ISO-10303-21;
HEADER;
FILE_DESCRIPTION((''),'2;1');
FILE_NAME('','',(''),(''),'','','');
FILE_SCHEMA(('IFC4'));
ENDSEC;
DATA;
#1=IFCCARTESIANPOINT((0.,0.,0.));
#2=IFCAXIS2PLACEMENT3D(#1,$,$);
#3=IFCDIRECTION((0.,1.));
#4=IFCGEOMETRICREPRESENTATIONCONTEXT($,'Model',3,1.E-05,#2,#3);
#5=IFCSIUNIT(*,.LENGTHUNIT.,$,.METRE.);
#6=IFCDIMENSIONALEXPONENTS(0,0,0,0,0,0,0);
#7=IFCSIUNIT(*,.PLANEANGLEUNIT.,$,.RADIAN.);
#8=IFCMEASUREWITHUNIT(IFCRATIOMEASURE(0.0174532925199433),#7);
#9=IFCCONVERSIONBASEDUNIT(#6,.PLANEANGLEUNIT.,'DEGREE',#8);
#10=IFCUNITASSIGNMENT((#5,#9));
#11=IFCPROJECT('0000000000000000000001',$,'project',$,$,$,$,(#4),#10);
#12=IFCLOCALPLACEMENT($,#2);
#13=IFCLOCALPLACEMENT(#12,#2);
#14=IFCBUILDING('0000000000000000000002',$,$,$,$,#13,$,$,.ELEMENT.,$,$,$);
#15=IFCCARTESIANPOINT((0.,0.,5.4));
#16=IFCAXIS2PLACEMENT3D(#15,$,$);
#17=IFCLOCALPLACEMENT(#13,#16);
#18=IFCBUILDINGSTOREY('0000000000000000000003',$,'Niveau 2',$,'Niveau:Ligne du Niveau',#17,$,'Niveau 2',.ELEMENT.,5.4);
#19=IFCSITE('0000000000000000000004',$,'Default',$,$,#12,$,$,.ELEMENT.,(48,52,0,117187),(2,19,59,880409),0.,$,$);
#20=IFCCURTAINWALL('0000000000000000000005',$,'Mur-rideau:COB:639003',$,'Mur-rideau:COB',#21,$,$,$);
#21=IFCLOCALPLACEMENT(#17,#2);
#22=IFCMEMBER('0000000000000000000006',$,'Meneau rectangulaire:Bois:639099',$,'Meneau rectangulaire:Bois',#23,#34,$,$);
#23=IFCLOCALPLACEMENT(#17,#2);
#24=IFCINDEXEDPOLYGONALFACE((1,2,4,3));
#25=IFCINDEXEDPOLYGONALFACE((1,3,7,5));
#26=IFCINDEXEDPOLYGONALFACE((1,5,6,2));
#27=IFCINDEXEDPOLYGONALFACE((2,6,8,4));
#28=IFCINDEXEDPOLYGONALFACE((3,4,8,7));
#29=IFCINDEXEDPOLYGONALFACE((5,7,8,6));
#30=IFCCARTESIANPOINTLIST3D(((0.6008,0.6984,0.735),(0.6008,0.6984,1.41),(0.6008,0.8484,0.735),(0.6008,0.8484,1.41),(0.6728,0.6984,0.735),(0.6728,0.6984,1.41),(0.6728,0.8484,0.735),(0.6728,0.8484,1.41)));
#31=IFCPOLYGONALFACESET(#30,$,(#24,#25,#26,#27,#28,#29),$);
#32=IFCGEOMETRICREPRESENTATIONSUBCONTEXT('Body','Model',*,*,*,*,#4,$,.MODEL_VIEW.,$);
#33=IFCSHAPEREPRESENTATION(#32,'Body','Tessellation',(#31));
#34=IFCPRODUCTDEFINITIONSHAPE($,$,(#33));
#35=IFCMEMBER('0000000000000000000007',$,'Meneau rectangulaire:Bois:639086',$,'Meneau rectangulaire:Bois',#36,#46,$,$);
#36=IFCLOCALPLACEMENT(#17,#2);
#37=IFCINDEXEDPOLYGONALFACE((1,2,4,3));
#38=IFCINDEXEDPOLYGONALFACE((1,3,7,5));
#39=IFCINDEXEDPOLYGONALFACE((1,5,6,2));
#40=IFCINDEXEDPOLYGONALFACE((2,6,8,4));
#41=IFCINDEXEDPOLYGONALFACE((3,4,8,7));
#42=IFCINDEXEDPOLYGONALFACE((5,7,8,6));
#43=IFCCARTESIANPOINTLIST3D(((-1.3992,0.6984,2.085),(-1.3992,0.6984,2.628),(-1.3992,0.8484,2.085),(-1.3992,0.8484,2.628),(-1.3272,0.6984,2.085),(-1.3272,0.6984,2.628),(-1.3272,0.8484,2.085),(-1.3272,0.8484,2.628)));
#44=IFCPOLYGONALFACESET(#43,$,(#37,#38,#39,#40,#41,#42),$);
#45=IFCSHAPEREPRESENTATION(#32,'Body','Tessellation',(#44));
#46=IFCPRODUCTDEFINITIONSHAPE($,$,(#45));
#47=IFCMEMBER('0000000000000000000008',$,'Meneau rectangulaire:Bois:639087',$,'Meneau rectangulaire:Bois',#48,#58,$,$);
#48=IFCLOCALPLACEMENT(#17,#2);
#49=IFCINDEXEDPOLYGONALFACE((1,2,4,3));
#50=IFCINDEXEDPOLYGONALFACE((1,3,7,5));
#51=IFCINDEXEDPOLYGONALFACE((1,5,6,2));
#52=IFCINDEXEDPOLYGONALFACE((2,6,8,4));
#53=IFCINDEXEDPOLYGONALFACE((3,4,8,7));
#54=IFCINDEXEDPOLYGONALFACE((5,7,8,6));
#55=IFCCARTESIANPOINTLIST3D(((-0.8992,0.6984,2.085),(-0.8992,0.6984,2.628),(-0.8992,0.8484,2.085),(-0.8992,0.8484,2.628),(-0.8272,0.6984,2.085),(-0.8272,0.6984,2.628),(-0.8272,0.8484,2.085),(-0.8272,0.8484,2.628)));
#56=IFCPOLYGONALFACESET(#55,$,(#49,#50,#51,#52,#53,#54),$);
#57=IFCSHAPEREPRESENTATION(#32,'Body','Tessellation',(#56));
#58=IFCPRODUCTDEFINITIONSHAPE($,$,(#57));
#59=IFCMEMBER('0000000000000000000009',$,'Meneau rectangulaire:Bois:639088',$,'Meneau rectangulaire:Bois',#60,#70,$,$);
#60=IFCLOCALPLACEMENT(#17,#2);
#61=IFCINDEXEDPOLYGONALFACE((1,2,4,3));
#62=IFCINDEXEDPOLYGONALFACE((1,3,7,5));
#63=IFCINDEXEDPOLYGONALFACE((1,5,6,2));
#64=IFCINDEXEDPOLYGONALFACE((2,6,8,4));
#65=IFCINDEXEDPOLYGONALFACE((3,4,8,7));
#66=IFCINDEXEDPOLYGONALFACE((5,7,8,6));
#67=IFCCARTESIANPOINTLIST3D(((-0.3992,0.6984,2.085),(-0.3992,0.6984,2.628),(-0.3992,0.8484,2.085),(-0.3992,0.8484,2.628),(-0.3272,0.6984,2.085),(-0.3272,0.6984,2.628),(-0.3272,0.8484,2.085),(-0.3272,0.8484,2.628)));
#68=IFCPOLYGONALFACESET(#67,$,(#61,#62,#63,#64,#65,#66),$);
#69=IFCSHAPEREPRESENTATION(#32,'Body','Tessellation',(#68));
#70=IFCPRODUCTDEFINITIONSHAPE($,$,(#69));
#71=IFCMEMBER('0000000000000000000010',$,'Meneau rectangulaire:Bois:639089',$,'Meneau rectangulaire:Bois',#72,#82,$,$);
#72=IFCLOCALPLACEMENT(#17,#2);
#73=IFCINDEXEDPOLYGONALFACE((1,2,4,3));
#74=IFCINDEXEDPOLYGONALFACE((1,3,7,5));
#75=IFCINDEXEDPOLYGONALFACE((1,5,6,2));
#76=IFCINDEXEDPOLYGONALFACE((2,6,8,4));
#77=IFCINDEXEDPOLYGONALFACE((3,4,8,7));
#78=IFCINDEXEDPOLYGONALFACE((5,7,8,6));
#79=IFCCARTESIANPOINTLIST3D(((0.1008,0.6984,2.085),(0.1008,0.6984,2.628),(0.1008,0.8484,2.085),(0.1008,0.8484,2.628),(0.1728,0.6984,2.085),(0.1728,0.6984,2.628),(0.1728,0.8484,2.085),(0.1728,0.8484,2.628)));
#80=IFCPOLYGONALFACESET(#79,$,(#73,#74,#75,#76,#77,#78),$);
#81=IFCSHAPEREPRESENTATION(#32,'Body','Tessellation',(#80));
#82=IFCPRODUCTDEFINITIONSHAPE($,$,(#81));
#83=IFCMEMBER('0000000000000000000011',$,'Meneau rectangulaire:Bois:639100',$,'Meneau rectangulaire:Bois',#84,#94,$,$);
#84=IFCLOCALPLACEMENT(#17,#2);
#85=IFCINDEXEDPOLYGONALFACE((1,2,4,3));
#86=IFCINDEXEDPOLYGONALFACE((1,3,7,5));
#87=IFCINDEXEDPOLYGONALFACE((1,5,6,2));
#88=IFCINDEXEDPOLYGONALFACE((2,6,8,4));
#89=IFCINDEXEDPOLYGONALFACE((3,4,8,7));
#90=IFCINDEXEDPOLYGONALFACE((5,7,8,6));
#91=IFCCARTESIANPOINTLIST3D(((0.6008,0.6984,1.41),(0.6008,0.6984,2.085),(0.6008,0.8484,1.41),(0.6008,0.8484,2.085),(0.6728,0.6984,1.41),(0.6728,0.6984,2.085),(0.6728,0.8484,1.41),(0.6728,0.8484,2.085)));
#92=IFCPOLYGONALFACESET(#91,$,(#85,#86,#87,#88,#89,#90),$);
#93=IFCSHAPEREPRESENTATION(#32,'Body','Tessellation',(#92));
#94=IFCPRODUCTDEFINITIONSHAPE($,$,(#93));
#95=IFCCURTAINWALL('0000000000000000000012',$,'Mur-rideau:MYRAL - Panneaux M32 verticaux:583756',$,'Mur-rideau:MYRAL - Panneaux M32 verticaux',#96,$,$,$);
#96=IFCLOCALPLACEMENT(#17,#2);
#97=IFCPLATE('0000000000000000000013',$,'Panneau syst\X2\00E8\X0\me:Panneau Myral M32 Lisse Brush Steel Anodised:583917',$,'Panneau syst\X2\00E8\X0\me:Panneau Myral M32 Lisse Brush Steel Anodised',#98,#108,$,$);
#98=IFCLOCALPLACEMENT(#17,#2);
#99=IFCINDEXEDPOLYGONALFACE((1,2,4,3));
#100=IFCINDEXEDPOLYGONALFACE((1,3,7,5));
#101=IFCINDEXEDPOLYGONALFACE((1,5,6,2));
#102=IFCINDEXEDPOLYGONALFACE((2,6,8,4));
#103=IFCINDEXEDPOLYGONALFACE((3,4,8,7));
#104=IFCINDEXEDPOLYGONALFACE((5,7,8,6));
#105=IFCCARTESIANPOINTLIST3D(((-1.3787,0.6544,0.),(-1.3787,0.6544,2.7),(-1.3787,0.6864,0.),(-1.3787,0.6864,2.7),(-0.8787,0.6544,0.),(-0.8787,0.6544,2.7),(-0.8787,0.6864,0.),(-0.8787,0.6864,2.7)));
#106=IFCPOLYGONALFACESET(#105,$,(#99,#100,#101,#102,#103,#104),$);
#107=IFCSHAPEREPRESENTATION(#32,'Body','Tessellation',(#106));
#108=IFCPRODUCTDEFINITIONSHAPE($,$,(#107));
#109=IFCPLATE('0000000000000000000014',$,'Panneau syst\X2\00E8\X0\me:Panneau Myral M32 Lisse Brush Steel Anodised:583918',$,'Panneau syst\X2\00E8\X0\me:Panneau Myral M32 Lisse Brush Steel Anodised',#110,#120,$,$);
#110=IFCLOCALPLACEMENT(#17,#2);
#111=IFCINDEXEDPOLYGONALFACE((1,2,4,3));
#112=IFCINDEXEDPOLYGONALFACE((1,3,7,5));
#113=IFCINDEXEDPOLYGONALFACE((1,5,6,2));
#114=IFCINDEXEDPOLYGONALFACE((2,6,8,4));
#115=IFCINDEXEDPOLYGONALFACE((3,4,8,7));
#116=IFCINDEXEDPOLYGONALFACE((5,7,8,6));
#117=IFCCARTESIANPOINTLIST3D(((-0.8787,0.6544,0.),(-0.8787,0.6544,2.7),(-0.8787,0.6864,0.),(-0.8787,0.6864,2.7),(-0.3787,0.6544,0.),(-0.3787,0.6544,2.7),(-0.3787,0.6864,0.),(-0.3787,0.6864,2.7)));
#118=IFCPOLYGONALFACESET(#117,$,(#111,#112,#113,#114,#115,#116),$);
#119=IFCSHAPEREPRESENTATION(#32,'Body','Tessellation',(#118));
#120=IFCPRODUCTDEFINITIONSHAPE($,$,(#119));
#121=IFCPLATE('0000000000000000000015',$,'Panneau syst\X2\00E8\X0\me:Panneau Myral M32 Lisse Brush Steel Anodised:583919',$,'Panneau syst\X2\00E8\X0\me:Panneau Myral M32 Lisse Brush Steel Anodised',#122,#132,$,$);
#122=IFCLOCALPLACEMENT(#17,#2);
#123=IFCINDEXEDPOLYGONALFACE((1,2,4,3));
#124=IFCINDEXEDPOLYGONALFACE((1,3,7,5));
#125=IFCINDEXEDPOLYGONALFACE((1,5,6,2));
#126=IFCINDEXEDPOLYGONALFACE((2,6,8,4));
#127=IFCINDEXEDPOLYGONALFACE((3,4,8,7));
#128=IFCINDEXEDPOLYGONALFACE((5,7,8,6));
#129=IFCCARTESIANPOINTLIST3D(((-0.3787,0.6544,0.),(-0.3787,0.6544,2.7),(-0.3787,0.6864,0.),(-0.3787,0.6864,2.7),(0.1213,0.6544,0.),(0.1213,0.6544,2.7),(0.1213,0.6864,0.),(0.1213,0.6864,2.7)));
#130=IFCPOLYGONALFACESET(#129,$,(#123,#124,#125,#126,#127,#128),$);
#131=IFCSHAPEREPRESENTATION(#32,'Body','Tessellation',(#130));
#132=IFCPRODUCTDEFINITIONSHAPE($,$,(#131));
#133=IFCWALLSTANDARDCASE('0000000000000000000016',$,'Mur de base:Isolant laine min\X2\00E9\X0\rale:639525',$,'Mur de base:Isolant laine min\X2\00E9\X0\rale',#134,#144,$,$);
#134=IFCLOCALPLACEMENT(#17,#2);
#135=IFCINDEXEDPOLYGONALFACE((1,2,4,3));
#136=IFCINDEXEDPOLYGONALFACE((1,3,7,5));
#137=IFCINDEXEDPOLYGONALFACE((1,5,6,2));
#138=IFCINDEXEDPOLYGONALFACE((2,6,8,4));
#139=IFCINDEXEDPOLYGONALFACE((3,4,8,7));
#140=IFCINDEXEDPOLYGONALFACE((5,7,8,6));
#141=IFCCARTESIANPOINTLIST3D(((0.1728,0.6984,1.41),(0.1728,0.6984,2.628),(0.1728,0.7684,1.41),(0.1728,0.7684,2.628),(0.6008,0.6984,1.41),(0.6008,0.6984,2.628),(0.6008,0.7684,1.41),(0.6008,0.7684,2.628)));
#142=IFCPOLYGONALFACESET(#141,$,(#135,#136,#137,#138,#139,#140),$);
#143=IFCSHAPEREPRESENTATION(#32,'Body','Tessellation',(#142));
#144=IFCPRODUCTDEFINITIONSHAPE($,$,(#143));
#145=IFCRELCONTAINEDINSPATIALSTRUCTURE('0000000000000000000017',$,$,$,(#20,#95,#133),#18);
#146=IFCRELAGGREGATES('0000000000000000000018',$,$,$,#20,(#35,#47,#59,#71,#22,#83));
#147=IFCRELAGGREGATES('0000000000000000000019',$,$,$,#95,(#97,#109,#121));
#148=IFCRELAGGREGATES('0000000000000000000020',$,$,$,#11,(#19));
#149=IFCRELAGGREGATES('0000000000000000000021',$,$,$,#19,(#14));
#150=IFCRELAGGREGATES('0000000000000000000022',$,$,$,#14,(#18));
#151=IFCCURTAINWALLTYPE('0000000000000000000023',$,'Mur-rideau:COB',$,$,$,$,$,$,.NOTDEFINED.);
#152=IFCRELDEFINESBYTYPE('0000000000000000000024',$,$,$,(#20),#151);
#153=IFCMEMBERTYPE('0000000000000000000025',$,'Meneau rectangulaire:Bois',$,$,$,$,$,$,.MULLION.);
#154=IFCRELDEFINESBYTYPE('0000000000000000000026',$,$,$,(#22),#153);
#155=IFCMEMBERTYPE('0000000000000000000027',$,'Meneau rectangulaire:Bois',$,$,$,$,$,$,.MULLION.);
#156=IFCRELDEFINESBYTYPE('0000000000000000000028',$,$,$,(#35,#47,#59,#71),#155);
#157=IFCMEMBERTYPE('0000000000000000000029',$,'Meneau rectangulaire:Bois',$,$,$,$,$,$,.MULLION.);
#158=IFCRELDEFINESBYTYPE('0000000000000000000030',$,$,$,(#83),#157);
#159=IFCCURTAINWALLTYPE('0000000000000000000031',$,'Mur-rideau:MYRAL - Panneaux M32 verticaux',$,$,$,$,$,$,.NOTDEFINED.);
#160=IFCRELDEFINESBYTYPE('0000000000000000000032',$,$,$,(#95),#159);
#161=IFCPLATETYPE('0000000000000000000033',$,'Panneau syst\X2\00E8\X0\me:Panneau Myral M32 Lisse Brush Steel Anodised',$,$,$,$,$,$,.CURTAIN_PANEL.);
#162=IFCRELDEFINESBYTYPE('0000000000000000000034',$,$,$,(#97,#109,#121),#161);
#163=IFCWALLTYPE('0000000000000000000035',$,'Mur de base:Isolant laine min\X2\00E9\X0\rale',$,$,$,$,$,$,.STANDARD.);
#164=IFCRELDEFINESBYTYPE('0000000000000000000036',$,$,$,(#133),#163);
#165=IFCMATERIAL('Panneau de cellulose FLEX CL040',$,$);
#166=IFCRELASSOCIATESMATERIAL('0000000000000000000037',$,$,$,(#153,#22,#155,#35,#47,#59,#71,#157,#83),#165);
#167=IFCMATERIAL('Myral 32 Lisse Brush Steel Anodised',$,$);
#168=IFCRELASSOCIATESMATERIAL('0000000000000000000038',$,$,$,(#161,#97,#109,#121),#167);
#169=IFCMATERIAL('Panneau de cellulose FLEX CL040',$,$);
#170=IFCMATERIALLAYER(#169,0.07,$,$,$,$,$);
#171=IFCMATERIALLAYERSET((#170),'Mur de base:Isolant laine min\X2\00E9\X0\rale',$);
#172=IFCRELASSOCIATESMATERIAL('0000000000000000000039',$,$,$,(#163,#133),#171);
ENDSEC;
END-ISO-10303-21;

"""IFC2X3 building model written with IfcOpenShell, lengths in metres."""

from ifc_helpers import new_model, entity, si_unit, converted_unit, direction, frame, frame_2d, origin, origin_2d_with_axis, place, context, subcontext, project, spatial, rectangle, extrude, source, transform, mapped, material, layer, layer_set, layer_usage, type_object, type_shapes, element, aggregate, save


model = new_model("IFC2X3")

# Units and contexts
model_context = context("Model", 3, precision=1e-05, world=origin(), true_north=direction((0.0, 1.0)))
body_context = subcontext(model_context, "Body", "Model", "MODEL_VIEW")
ifc_project = project(units=[si_unit("LENGTHUNIT", "METRE"), converted_unit("PLANEANGLEUNIT", "DEGREE", entity("IfcRatioMeasure", 0.0174532925199433), si_unit("PLANEANGLEUNIT", "RADIAN"), dimensions=[0, 0, 0, 0, 0, 0, 0])], contexts=[model_context])

# Site, building, storey
site_placement = place(None, origin())
site = spatial("IfcSite", under=ifc_project, at=site_placement, Name="Default", CompositionType="ELEMENT", RefLatitude=(48, 52, 0, 117187), RefLongitude=(2, 19, 59, 880409), RefElevation=0.0)
building_placement = place(site_placement, origin())
building = spatial("IfcBuilding", under=site, at=building_placement, CompositionType="ELEMENT")
storey_placement = place(building_placement, frame((0.0, 0.0, 5.4)))
storey = spatial("IfcBuildingStorey", under=building, at=storey_placement, Name="Niveau 2", ObjectType="Niveau:Ligne du Niveau", LongName="Niveau 2", CompositionType="ELEMENT", Elevation=5.4)

# Curtain wall, members
curtain_wall_type_1 = type_object("IfcCurtainWallType", Name="Mur-rideau:COB", PredefinedType="NOTDEFINED")
curtain_wall_1_placement = place(storey_placement, frame((0.0, 0.0, -5.4)))
curtain_wall_1 = element("IfcCurtainWall", 1, at=curtain_wall_1_placement, inside=storey, type_object=curtain_wall_type_1, Name="Mur-rideau:COB:639003", ObjectType="Mur-rideau:COB")
ifc_material_1 = material(Name="Panneau de cellulose FLEX CL040")
member_type_1 = type_object("IfcMemberType", Name="Meneau rectangulaire:Bois", PredefinedType="MULLION", material=ifc_material_1)
shared_shape_1 = source(origin(), body_context, "Body", "SweptSolid", [
    extrude(rectangle(XDim=0.15, YDim=0.072, at=origin_2d_with_axis()), frame((-0.024, 0.0, -0.675), z_axis=(0.0, 0.0, 1.0), x_axis=(0.0, -1.0, 0.0)), (0.0, 0.0, 1.0), 0.675),
])
type_shapes(member_type_1, [shared_shape_1])
member_1_placement = place(storey_placement, frame((0.6608, 0.7734, 0.735), z_axis=(0.0, 0.0, -1.0), x_axis=(1.0, 0.0, 0.0)))
member_1 = element("IfcMember", 2, at=member_1_placement, type_object=member_type_1, material=ifc_material_1, Name="Meneau rectangulaire:Bois:639099", ObjectType="Meneau rectangulaire:Bois", context=body_context, shape_type="MappedRepresentation", body=[
    mapped(shared_shape_1, transform((0.0, 0.0, 0.0), scale=1.0)),
])
member_type_2 = type_object("IfcMemberType", Name="Meneau rectangulaire:Bois", PredefinedType="MULLION", material=ifc_material_1)
shared_shape_2 = source(origin(), body_context, "Body", "SweptSolid", [
    extrude(rectangle(XDim=0.15, YDim=0.072, at=origin_2d_with_axis()), frame((-0.024, 0.0, -0.543), z_axis=(0.0, 0.0, 1.0), x_axis=(0.0, -1.0, 0.0)), (0.0, 0.0, 1.0), 0.543),
])
type_shapes(member_type_2, [shared_shape_2])
member_2_placement = place(storey_placement, frame((-1.3392, 0.7734, 2.085), z_axis=(0.0, 0.0, -1.0), x_axis=(1.0, 0.0, 0.0)))
member_2 = element("IfcMember", 3, at=member_2_placement, type_object=member_type_2, material=ifc_material_1, Name="Meneau rectangulaire:Bois:639086", ObjectType="Meneau rectangulaire:Bois", context=body_context, shape_type="MappedRepresentation", body=[
    mapped(shared_shape_2, transform((0.0, 0.0, 0.0), scale=1.0)),
])
member_3_placement = place(storey_placement, frame((-0.8392, 0.7734, 2.085), z_axis=(0.0, 0.0, -1.0), x_axis=(1.0, 0.0, 0.0)))
member_3 = element("IfcMember", 4, at=member_3_placement, type_object=member_type_2, material=ifc_material_1, Name="Meneau rectangulaire:Bois:639087", ObjectType="Meneau rectangulaire:Bois", context=body_context, shape_type="MappedRepresentation", body=[
    mapped(shared_shape_2, transform((0.0, 0.0, 0.0), scale=1.0)),
])
member_4_placement = place(storey_placement, frame((-0.3392, 0.7734, 2.085), z_axis=(0.0, 0.0, -1.0), x_axis=(1.0, 0.0, 0.0)))
member_4 = element("IfcMember", 5, at=member_4_placement, type_object=member_type_2, material=ifc_material_1, Name="Meneau rectangulaire:Bois:639088", ObjectType="Meneau rectangulaire:Bois", context=body_context, shape_type="MappedRepresentation", body=[
    mapped(shared_shape_2, transform((0.0, 0.0, 0.0), scale=1.0)),
])
member_5_placement = place(storey_placement, frame((0.1608, 0.7734, 2.085), z_axis=(0.0, 0.0, -1.0), x_axis=(1.0, 0.0, 0.0)))
member_5 = element("IfcMember", 6, at=member_5_placement, type_object=member_type_2, material=ifc_material_1, Name="Meneau rectangulaire:Bois:639089", ObjectType="Meneau rectangulaire:Bois", context=body_context, shape_type="MappedRepresentation", body=[
    mapped(shared_shape_2, transform((0.0, 0.0, 0.0), scale=1.0)),
])
member_type_3 = type_object("IfcMemberType", Name="Meneau rectangulaire:Bois", PredefinedType="MULLION", material=ifc_material_1)
shared_shape_3 = source(origin(), body_context, "Body", "SweptSolid", [
    extrude(rectangle(XDim=0.15, YDim=0.072, at=origin_2d_with_axis()), frame((-0.024, 0.0, -0.675), z_axis=(0.0, 0.0, 1.0), x_axis=(0.0, -1.0, 0.0)), (0.0, 0.0, 1.0), 0.675),
])
type_shapes(member_type_3, [shared_shape_3])
member_6_placement = place(storey_placement, frame((0.6608, 0.7734, 1.41), z_axis=(0.0, 0.0, -1.0), x_axis=(1.0, 0.0, 0.0)))
member_6 = element("IfcMember", 7, at=member_6_placement, type_object=member_type_3, material=ifc_material_1, Name="Meneau rectangulaire:Bois:639100", ObjectType="Meneau rectangulaire:Bois", context=body_context, shape_type="MappedRepresentation", body=[
    mapped(shared_shape_3, transform((0.0, 0.0, 0.0), scale=1.0)),
])
aggregate(curtain_wall_1, [member_2, member_3, member_4, member_5, member_1, member_6])

# Curtain wall, plates
curtain_wall_type_2 = type_object("IfcCurtainWallType", Name="Mur-rideau:MYRAL - Panneaux M32 verticaux", PredefinedType="NOTDEFINED")
curtain_wall_2_placement = place(storey_placement, frame((0.0, 0.0, -5.4)))
curtain_wall_2 = element("IfcCurtainWall", 8, at=curtain_wall_2_placement, inside=storey, type_object=curtain_wall_type_2, Name="Mur-rideau:MYRAL - Panneaux M32 verticaux:583756", ObjectType="Mur-rideau:MYRAL - Panneaux M32 verticaux")
ifc_material_2 = material(Name="Myral 32 Lisse Brush Steel Anodised")
plate_type = type_object("IfcPlateType", Name="Panneau système:Panneau Myral M32 Lisse Brush Steel Anodised", PredefinedType="CURTAIN_PANEL", material=ifc_material_2)
shared_shape_4 = source(origin(), body_context, "Body", "SweptSolid", [
    extrude(rectangle(XDim=0.032, YDim=0.5, at=origin_2d_with_axis()), frame((0.0, -0.016, 0.0), z_axis=(0.0, 0.0, 1.0), x_axis=(0.0, 1.0, 0.0)), (0.0, 0.0, 1.0), 2.7),
])
type_shapes(plate_type, [shared_shape_4])
plate_1_placement = place(curtain_wall_2_placement, frame((-1.1287, 0.6864, 5.4)))
plate_1 = element("IfcPlate", 9, at=plate_1_placement, type_object=plate_type, material=ifc_material_2, Name="Panneau système:Panneau Myral M32 Lisse Brush Steel Anodised:583917", ObjectType="Panneau système:Panneau Myral M32 Lisse Brush Steel Anodised", context=body_context, shape_type="MappedRepresentation", body=[
    mapped(shared_shape_4, transform((0.0, 0.0, 0.0), scale=1.0)),
])
plate_2_placement = place(curtain_wall_2_placement, frame((-0.6287, 0.6864, 5.4)))
plate_2 = element("IfcPlate", 10, at=plate_2_placement, type_object=plate_type, material=ifc_material_2, Name="Panneau système:Panneau Myral M32 Lisse Brush Steel Anodised:583918", ObjectType="Panneau système:Panneau Myral M32 Lisse Brush Steel Anodised", context=body_context, shape_type="MappedRepresentation", body=[
    mapped(shared_shape_4, transform((0.0, 0.0, 0.0), scale=1.0)),
])
plate_3_placement = place(curtain_wall_2_placement, frame((-0.1287, 0.6864, 5.4)))
plate_3 = element("IfcPlate", 11, at=plate_3_placement, type_object=plate_type, material=ifc_material_2, Name="Panneau système:Panneau Myral M32 Lisse Brush Steel Anodised:583919", ObjectType="Panneau système:Panneau Myral M32 Lisse Brush Steel Anodised", context=body_context, shape_type="MappedRepresentation", body=[
    mapped(shared_shape_4, transform((0.0, 0.0, 0.0), scale=1.0)),
])
aggregate(curtain_wall_2, [plate_1, plate_2, plate_3])

# Wall
ifc_material_3 = material(Name="Panneau de cellulose FLEX CL040")
ifc_layer = layer(ifc_material_3, 0.07)
ifc_layer_set = layer_set([ifc_layer], Name="Mur de base:Isolant laine minérale")
ifc_layer_usage = layer_usage(ifc_layer_set, "AXIS2", "NEGATIVE", 0.035)
wall_type = type_object("IfcWallType", Name="Mur de base:Isolant laine minérale", PredefinedType="STANDARD", material=ifc_layer_set)
wall_placement = place(storey_placement, frame((0.1728, 0.7334, 1.41)))
element("IfcWallStandardCase", 12, at=wall_placement, inside=storey, type_object=wall_type, material=ifc_layer_usage, Name="Mur de base:Isolant laine minérale:639525", ObjectType="Mur de base:Isolant laine minérale", context=body_context, shape_type="SweptSolid", body=[
    extrude(rectangle(XDim=0.428, YDim=0.07, at=frame_2d((0.214, 0.0), x_axis=(-1.0, 0.0))), origin(), (0.0, 0.0, 1.0), 1.218),
])

save(model, "model.ifc")
